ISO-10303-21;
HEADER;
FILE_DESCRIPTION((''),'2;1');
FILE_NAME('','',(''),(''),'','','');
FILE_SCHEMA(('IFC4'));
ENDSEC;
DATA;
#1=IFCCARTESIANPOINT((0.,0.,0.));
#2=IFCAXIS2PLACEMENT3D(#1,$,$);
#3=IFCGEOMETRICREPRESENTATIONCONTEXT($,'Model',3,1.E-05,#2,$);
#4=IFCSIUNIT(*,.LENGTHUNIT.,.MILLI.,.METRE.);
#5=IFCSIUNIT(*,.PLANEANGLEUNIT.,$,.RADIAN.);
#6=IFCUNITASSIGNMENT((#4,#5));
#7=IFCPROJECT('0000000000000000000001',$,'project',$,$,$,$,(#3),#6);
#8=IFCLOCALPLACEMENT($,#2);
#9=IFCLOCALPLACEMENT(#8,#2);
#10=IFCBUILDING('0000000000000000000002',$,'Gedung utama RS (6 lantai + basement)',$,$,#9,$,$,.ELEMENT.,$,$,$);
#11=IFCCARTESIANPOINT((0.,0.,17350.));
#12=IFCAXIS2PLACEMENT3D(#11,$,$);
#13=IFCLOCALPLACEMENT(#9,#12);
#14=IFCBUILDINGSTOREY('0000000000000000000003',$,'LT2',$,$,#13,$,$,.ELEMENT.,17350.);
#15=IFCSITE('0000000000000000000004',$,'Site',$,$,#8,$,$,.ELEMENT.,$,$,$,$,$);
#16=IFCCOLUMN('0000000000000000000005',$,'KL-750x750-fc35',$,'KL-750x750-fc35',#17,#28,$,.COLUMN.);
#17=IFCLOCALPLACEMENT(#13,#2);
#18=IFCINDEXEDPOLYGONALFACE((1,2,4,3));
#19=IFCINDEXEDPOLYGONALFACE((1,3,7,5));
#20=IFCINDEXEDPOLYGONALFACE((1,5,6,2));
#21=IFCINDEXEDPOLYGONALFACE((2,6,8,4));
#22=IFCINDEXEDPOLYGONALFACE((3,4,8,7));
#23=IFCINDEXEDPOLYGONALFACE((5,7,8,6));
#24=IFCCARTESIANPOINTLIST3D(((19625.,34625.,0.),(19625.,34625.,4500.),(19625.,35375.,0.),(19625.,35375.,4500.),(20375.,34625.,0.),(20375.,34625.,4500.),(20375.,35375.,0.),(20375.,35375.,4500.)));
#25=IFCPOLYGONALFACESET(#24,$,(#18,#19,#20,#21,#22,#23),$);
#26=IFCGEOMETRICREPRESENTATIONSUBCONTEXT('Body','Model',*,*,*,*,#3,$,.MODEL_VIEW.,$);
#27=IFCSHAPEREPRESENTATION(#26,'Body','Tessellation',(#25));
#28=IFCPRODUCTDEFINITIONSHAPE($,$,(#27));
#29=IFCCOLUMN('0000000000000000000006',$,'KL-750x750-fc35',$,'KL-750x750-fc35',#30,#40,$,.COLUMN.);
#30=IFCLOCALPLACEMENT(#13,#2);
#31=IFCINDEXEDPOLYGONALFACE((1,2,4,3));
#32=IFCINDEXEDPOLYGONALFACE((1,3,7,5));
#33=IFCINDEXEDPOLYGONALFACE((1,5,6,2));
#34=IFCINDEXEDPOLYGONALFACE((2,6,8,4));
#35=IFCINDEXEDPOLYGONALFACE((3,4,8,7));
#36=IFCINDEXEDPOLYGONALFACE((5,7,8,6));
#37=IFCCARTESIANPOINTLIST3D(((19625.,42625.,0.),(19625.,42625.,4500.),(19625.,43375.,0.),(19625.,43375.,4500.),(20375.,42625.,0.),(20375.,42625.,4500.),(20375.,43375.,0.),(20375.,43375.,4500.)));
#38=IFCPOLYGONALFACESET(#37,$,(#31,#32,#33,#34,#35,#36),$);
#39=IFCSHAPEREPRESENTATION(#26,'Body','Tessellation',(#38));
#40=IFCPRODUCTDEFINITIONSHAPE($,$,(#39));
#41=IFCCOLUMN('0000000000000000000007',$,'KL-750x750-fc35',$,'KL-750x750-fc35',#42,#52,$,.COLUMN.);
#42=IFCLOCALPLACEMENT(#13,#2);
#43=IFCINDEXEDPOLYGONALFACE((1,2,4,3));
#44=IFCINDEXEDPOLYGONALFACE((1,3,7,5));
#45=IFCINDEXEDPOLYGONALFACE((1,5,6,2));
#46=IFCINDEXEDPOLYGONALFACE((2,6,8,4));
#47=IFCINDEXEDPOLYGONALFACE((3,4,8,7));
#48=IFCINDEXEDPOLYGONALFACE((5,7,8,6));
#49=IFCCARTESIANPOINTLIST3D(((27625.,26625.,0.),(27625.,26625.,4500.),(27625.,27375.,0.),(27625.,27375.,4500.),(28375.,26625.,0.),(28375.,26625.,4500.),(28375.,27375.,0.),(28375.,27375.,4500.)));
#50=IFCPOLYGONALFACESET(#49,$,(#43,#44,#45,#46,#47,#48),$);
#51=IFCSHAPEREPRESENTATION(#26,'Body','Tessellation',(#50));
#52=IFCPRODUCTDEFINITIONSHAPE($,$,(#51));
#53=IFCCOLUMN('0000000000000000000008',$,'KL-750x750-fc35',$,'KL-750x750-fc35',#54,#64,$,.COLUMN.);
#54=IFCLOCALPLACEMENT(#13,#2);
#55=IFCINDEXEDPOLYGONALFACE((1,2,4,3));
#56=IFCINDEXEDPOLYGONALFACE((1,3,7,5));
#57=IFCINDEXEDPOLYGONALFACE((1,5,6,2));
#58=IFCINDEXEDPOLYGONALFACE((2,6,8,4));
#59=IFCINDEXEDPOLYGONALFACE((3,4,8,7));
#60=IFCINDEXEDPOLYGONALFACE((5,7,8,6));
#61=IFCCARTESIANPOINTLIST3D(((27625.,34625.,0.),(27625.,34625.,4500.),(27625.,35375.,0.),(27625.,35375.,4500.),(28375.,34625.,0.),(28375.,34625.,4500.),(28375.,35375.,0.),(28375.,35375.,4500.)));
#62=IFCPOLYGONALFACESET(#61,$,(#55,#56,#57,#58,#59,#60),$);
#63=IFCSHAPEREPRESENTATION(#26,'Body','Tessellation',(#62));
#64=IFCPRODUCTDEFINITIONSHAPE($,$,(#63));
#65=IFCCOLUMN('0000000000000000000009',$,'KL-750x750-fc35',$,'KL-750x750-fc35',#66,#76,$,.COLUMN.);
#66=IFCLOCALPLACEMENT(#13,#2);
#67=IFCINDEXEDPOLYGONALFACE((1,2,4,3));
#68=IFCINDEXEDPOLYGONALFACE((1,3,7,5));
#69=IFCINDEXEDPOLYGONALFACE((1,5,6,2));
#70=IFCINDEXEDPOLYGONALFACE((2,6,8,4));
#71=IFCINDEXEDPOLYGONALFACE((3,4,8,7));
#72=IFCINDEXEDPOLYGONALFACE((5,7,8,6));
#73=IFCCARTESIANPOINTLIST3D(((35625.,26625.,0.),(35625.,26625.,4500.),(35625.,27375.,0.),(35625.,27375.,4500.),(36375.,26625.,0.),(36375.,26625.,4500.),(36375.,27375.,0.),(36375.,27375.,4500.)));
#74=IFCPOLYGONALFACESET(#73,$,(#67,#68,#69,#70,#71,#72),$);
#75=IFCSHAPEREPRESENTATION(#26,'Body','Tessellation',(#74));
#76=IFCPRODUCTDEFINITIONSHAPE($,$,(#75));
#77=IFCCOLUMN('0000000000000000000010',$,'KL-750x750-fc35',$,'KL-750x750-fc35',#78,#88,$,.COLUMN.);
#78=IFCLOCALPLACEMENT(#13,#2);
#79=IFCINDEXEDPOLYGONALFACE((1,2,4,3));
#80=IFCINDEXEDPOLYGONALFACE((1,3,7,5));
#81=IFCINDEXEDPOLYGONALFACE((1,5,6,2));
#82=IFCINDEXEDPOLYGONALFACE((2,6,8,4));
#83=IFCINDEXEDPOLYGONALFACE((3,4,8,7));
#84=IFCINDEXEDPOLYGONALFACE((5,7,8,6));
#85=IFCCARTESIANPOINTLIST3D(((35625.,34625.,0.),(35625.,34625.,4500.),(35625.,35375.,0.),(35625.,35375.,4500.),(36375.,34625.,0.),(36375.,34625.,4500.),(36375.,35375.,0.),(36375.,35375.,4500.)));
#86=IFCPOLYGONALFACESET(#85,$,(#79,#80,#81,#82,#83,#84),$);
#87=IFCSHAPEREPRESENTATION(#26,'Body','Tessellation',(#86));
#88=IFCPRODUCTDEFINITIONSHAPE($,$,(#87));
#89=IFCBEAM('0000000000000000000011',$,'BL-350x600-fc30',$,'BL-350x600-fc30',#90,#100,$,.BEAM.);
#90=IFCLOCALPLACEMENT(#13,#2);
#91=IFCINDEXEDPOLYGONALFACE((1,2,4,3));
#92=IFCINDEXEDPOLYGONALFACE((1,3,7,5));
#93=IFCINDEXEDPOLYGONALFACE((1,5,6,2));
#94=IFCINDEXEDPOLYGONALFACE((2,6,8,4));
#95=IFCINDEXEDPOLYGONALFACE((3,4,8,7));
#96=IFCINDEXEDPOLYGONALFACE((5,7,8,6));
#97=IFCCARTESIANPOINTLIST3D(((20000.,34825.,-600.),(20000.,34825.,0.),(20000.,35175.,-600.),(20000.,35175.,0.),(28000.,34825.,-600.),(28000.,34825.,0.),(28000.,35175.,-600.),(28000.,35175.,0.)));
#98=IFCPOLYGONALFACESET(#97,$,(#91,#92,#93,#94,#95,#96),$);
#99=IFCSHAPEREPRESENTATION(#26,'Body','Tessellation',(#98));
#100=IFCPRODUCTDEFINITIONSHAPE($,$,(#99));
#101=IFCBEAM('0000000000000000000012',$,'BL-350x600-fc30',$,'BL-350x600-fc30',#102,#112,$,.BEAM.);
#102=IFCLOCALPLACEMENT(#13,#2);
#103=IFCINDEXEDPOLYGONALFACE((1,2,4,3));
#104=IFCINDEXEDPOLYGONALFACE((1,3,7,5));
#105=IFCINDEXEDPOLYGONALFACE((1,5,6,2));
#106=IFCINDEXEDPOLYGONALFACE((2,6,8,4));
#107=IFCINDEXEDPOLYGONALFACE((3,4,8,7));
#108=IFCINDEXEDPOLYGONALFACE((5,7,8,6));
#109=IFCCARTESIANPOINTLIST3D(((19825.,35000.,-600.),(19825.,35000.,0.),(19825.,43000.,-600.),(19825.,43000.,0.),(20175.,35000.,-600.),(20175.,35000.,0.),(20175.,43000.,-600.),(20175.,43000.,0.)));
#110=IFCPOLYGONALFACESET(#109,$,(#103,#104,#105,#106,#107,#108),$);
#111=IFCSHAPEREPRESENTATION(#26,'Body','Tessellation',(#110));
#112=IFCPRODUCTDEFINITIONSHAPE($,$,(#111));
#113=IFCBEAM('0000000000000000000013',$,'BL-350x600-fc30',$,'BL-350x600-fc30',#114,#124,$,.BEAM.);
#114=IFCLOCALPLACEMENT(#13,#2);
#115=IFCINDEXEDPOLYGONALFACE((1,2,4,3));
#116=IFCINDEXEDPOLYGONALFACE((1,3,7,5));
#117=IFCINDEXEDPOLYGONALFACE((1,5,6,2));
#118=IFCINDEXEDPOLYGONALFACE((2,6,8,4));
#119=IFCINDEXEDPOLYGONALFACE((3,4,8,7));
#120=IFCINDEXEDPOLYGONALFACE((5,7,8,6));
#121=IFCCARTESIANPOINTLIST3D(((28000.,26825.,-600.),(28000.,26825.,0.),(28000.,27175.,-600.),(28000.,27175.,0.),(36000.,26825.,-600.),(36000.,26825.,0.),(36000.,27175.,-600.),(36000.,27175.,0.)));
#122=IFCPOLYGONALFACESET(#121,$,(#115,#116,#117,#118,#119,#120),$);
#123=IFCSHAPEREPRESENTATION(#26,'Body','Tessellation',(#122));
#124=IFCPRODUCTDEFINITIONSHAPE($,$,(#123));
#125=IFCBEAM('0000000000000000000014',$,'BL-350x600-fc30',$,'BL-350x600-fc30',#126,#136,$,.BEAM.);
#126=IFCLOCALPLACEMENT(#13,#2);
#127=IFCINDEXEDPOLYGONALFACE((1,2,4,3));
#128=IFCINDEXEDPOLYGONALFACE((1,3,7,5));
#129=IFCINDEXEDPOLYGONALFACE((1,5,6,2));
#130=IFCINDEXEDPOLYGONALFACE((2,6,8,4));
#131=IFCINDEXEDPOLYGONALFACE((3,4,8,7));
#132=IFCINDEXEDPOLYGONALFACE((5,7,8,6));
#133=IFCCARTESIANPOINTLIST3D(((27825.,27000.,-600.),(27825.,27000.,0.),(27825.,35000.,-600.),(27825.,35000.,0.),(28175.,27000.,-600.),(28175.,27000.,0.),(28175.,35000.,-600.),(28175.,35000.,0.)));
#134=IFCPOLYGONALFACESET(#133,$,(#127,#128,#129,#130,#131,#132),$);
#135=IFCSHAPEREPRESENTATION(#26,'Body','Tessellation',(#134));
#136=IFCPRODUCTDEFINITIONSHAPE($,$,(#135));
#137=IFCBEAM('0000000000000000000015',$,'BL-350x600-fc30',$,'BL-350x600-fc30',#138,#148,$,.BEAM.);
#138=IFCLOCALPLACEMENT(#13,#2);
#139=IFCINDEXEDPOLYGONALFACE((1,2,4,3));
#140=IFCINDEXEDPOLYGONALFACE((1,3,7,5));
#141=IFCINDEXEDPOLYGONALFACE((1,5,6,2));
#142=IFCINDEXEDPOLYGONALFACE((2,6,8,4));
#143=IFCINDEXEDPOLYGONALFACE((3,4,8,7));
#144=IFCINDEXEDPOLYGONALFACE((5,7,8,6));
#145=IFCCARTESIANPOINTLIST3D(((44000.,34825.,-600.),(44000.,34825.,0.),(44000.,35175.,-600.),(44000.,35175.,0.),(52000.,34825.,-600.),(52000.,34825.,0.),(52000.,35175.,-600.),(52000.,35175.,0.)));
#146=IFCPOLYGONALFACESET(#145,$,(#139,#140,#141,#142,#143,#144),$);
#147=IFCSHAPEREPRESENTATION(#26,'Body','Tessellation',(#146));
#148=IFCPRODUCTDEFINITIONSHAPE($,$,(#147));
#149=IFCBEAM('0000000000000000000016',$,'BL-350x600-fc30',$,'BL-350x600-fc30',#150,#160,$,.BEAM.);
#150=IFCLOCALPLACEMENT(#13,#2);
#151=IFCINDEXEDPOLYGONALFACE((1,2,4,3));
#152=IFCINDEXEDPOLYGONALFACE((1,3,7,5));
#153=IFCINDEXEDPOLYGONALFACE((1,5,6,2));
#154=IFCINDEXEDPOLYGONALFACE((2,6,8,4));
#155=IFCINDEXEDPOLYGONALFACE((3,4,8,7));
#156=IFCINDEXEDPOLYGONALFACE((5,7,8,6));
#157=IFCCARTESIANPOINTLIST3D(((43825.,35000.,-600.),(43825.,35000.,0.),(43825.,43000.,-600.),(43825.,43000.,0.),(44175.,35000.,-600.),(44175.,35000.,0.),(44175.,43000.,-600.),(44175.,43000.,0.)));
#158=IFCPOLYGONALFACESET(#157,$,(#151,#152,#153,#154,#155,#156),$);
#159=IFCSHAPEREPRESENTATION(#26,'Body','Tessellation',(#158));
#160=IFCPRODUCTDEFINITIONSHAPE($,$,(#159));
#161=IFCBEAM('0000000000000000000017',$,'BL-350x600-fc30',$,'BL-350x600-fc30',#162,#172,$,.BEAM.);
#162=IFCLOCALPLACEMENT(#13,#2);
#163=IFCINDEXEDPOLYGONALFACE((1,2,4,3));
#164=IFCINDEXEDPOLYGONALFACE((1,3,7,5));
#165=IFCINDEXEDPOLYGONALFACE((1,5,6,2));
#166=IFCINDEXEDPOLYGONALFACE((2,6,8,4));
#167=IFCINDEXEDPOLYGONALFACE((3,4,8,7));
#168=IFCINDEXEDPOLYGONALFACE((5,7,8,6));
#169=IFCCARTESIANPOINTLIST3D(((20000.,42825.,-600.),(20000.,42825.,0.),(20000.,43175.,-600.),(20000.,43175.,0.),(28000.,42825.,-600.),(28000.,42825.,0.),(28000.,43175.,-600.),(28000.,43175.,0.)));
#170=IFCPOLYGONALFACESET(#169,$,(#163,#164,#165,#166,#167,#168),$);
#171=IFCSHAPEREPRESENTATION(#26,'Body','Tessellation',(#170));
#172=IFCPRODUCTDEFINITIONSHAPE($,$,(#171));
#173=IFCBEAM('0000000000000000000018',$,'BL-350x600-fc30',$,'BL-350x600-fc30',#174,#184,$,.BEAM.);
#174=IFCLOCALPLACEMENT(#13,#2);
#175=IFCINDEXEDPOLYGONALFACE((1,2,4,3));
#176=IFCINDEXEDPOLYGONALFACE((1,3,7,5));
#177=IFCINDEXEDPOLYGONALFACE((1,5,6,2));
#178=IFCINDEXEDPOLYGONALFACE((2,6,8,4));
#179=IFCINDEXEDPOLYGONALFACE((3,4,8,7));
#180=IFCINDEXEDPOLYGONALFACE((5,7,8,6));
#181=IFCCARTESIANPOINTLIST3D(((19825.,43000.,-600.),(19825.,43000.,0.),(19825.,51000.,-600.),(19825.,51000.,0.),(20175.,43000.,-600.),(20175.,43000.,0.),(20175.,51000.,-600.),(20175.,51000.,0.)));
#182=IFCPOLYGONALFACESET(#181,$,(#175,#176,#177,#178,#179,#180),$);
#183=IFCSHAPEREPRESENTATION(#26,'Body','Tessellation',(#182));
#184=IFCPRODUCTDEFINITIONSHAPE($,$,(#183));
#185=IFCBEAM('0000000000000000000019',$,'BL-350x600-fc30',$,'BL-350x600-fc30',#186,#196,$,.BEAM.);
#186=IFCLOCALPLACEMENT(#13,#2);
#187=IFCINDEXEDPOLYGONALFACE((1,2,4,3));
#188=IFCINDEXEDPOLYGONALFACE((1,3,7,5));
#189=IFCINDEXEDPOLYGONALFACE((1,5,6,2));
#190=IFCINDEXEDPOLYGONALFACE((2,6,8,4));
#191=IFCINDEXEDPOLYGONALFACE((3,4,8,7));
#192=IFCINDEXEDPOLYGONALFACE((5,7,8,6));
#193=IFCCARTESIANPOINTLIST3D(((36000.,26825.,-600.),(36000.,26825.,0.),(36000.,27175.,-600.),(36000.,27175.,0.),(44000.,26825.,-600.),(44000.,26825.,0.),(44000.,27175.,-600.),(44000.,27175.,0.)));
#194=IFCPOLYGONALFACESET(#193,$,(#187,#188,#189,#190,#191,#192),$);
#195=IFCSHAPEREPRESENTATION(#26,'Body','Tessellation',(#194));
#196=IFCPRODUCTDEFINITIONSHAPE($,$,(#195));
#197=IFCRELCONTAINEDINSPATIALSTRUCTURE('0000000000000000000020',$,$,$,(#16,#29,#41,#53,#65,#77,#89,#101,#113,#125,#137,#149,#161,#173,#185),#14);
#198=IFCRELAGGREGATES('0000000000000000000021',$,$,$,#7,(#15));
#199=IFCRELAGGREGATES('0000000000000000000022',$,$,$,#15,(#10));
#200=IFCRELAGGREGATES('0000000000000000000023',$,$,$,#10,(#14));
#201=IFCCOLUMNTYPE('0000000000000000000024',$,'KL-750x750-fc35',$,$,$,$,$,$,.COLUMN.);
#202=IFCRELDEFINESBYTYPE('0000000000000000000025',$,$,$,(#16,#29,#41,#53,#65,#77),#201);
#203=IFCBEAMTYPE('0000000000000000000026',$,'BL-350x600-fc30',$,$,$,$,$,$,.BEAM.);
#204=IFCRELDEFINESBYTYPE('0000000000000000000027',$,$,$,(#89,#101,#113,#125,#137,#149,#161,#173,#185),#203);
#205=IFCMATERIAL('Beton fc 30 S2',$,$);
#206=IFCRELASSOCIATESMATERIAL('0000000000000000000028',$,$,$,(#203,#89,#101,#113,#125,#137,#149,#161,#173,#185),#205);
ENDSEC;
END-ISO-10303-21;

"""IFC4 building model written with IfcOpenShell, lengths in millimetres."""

from ifc_helpers import new_model, si_unit, frame, origin, origin_2d, place, context, subcontext, project, spatial, rectangle, extrude, material, material_profile, profile_set, profile_usage, type_object, element, save


model = new_model("IFC4")

# Units and contexts
model_context = context("Model", 3, precision=1e-05, world=origin())
body_context = subcontext(model_context, "Body", "Model", "MODEL_VIEW")
ifc_project = project(units=[si_unit("LENGTHUNIT", "METRE", prefix="MILLI"), si_unit("PLANEANGLEUNIT", "RADIAN")], contexts=[model_context])

# Site, building, storey
site_placement = place(None, origin())
site = spatial("IfcSite", under=ifc_project, at=site_placement, Name="Site", CompositionType="ELEMENT")
building_placement = place(site_placement, origin())
building = spatial("IfcBuilding", under=site, at=building_placement, Name="Gedung utama RS (6 lantai + basement)", CompositionType="ELEMENT")
storey_placement = place(building_placement, frame((0.0, 0.0, 17350.0)))
storey = spatial("IfcBuildingStorey", under=building, at=storey_placement, Name="LT2", CompositionType="ELEMENT", Elevation=17350.0)

# Columns
ifc_material_profile_1 = material_profile(None, rectangle(XDim=750.0, YDim=750.0, at=origin_2d()), Name="KL-750x750-fc35")
ifc_profile_set_1 = profile_set([ifc_material_profile_1], Name="KL-750x750-fc35")
ifc_profile_usage_1 = profile_usage(ifc_profile_set_1, cardinal=5)
column_type = type_object("IfcColumnType", Name="KL-750x750-fc35", PredefinedType="COLUMN", material=ifc_profile_set_1)
for number, where, z_axis, x_axis, name in (
    (1, (20000.0, 35000.0, 0.0), (0.0, 0.0, 1.0), (1.0, 0.0, 0.0), "KL-750x750-fc35"),
    (2, (20000.0, 43000.0, 0.0), (0.0, 0.0, 1.0), (1.0, 0.0, 0.0), "KL-750x750-fc35"),
    (3, (28000.0, 27000.0, 0.0), (0.0, 0.0, 1.0), (1.0, 0.0, 0.0), "KL-750x750-fc35"),
    (4, (28000.0, 35000.0, 0.0), (0.0, 0.0, 1.0), (1.0, 0.0, 0.0), "KL-750x750-fc35"),
    (5, (36000.0, 27000.0, 0.0), (0.0, 0.0, 1.0), (1.0, 0.0, 0.0), "KL-750x750-fc35"),
    (6, (36000.0, 35000.0, 0.0), (0.0, 0.0, 1.0), (1.0, 0.0, 0.0), "KL-750x750-fc35"),
):
    element("IfcColumn", number, at=place(storey_placement, frame(where, z_axis=z_axis, x_axis=x_axis)), inside=storey, type_object=column_type, material=ifc_profile_usage_1, Name=name, ObjectType="KL-750x750-fc35", PredefinedType="COLUMN", context=body_context, shape_type="SweptSolid", body=[
        extrude(rectangle(XDim=750.0, YDim=750.0, at=origin_2d()), origin(), (0.0, 0.0, 1.0), 4500.0),
    ])

# Beams
ifc_material_1 = material(Name="Beton fc 30 S2")
ifc_material_profile_2 = material_profile(ifc_material_1, rectangle(XDim=350.0, YDim=600.0, at=origin_2d()), Name="BL-350x600-fc30")
ifc_profile_set_2 = profile_set([ifc_material_profile_2], Name="BL-350x600-fc30")
ifc_profile_usage_2 = profile_usage(ifc_profile_set_2, cardinal=8)
beam_type = type_object("IfcBeamType", Name="BL-350x600-fc30", PredefinedType="BEAM", material=ifc_profile_set_2)
beam_1_placement = place(storey_placement, frame((20000.0, 35000.0, -300.0)))
element("IfcBeam", 7, at=beam_1_placement, inside=storey, type_object=beam_type, material=ifc_profile_usage_2, Name="BL-350x600-fc30", ObjectType="BL-350x600-fc30", PredefinedType="BEAM", context=body_context, shape_type="SweptSolid", body=[
    extrude(rectangle(XDim=350.0, YDim=600.0, at=origin_2d()), frame((0.0, 0.0, 0.0), z_axis=(1.0, 0.0, 0.0), x_axis=(0.0, 1.0, 0.0)), (0.0, 0.0, 1.0), 8000.0),
])
beam_2_placement = place(storey_placement, frame((20000.0, 35000.0, -300.0)))
element("IfcBeam", 8, at=beam_2_placement, inside=storey, type_object=beam_type, material=ifc_profile_usage_2, Name="BL-350x600-fc30", ObjectType="BL-350x600-fc30", PredefinedType="BEAM", context=body_context, shape_type="SweptSolid", body=[
    extrude(rectangle(XDim=350.0, YDim=600.0, at=origin_2d()), frame((0.0, 0.0, 0.0), z_axis=(0.0, 1.0, 0.0), x_axis=(-1.0, 0.0, 0.0)), (0.0, 0.0, 1.0), 8000.0),
])
beam_3_placement = place(storey_placement, frame((28000.0, 27000.0, -300.0)))
element("IfcBeam", 9, at=beam_3_placement, inside=storey, type_object=beam_type, material=ifc_profile_usage_2, Name="BL-350x600-fc30", ObjectType="BL-350x600-fc30", PredefinedType="BEAM", context=body_context, shape_type="SweptSolid", body=[
    extrude(rectangle(XDim=350.0, YDim=600.0, at=origin_2d()), frame((0.0, 0.0, 0.0), z_axis=(1.0, 0.0, 0.0), x_axis=(0.0, 1.0, 0.0)), (0.0, 0.0, 1.0), 8000.0),
])
beam_4_placement = place(storey_placement, frame((28000.0, 27000.0, -300.0)))
element("IfcBeam", 10, at=beam_4_placement, inside=storey, type_object=beam_type, material=ifc_profile_usage_2, Name="BL-350x600-fc30", ObjectType="BL-350x600-fc30", PredefinedType="BEAM", context=body_context, shape_type="SweptSolid", body=[
    extrude(rectangle(XDim=350.0, YDim=600.0, at=origin_2d()), frame((0.0, 0.0, 0.0), z_axis=(0.0, 1.0, 0.0), x_axis=(-1.0, 0.0, 0.0)), (0.0, 0.0, 1.0), 8000.0),
])
beam_5_placement = place(storey_placement, frame((44000.0, 35000.0, -300.0)))
element("IfcBeam", 11, at=beam_5_placement, inside=storey, type_object=beam_type, material=ifc_profile_usage_2, Name="BL-350x600-fc30", ObjectType="BL-350x600-fc30", PredefinedType="BEAM", context=body_context, shape_type="SweptSolid", body=[
    extrude(rectangle(XDim=350.0, YDim=600.0, at=origin_2d()), frame((0.0, 0.0, 0.0), z_axis=(1.0, 0.0, 0.0), x_axis=(0.0, 1.0, 0.0)), (0.0, 0.0, 1.0), 8000.0),
])
beam_6_placement = place(storey_placement, frame((44000.0, 35000.0, -300.0)))
element("IfcBeam", 12, at=beam_6_placement, inside=storey, type_object=beam_type, material=ifc_profile_usage_2, Name="BL-350x600-fc30", ObjectType="BL-350x600-fc30", PredefinedType="BEAM", context=body_context, shape_type="SweptSolid", body=[
    extrude(rectangle(XDim=350.0, YDim=600.0, at=origin_2d()), frame((0.0, 0.0, 0.0), z_axis=(0.0, 1.0, 0.0), x_axis=(-1.0, 0.0, 0.0)), (0.0, 0.0, 1.0), 8000.0),
])
beam_7_placement = place(storey_placement, frame((20000.0, 43000.0, -300.0)))
element("IfcBeam", 13, at=beam_7_placement, inside=storey, type_object=beam_type, material=ifc_profile_usage_2, Name="BL-350x600-fc30", ObjectType="BL-350x600-fc30", PredefinedType="BEAM", context=body_context, shape_type="SweptSolid", body=[
    extrude(rectangle(XDim=350.0, YDim=600.0, at=origin_2d()), frame((0.0, 0.0, 0.0), z_axis=(1.0, 0.0, 0.0), x_axis=(0.0, 1.0, 0.0)), (0.0, 0.0, 1.0), 8000.0),
])
beam_8_placement = place(storey_placement, frame((20000.0, 43000.0, -300.0)))
element("IfcBeam", 14, at=beam_8_placement, inside=storey, type_object=beam_type, material=ifc_profile_usage_2, Name="BL-350x600-fc30", ObjectType="BL-350x600-fc30", PredefinedType="BEAM", context=body_context, shape_type="SweptSolid", body=[
    extrude(rectangle(XDim=350.0, YDim=600.0, at=origin_2d()), frame((0.0, 0.0, 0.0), z_axis=(0.0, 1.0, 0.0), x_axis=(-1.0, 0.0, 0.0)), (0.0, 0.0, 1.0), 8000.0),
])
beam_9_placement = place(storey_placement, frame((36000.0, 27000.0, -300.0)))
element("IfcBeam", 15, at=beam_9_placement, inside=storey, type_object=beam_type, material=ifc_profile_usage_2, Name="BL-350x600-fc30", ObjectType="BL-350x600-fc30", PredefinedType="BEAM", context=body_context, shape_type="SweptSolid", body=[
    extrude(rectangle(XDim=350.0, YDim=600.0, at=origin_2d()), frame((0.0, 0.0, 0.0), z_axis=(1.0, 0.0, 0.0), x_axis=(0.0, 1.0, 0.0)), (0.0, 0.0, 1.0), 8000.0),
])

save(model, "model.ifc")
